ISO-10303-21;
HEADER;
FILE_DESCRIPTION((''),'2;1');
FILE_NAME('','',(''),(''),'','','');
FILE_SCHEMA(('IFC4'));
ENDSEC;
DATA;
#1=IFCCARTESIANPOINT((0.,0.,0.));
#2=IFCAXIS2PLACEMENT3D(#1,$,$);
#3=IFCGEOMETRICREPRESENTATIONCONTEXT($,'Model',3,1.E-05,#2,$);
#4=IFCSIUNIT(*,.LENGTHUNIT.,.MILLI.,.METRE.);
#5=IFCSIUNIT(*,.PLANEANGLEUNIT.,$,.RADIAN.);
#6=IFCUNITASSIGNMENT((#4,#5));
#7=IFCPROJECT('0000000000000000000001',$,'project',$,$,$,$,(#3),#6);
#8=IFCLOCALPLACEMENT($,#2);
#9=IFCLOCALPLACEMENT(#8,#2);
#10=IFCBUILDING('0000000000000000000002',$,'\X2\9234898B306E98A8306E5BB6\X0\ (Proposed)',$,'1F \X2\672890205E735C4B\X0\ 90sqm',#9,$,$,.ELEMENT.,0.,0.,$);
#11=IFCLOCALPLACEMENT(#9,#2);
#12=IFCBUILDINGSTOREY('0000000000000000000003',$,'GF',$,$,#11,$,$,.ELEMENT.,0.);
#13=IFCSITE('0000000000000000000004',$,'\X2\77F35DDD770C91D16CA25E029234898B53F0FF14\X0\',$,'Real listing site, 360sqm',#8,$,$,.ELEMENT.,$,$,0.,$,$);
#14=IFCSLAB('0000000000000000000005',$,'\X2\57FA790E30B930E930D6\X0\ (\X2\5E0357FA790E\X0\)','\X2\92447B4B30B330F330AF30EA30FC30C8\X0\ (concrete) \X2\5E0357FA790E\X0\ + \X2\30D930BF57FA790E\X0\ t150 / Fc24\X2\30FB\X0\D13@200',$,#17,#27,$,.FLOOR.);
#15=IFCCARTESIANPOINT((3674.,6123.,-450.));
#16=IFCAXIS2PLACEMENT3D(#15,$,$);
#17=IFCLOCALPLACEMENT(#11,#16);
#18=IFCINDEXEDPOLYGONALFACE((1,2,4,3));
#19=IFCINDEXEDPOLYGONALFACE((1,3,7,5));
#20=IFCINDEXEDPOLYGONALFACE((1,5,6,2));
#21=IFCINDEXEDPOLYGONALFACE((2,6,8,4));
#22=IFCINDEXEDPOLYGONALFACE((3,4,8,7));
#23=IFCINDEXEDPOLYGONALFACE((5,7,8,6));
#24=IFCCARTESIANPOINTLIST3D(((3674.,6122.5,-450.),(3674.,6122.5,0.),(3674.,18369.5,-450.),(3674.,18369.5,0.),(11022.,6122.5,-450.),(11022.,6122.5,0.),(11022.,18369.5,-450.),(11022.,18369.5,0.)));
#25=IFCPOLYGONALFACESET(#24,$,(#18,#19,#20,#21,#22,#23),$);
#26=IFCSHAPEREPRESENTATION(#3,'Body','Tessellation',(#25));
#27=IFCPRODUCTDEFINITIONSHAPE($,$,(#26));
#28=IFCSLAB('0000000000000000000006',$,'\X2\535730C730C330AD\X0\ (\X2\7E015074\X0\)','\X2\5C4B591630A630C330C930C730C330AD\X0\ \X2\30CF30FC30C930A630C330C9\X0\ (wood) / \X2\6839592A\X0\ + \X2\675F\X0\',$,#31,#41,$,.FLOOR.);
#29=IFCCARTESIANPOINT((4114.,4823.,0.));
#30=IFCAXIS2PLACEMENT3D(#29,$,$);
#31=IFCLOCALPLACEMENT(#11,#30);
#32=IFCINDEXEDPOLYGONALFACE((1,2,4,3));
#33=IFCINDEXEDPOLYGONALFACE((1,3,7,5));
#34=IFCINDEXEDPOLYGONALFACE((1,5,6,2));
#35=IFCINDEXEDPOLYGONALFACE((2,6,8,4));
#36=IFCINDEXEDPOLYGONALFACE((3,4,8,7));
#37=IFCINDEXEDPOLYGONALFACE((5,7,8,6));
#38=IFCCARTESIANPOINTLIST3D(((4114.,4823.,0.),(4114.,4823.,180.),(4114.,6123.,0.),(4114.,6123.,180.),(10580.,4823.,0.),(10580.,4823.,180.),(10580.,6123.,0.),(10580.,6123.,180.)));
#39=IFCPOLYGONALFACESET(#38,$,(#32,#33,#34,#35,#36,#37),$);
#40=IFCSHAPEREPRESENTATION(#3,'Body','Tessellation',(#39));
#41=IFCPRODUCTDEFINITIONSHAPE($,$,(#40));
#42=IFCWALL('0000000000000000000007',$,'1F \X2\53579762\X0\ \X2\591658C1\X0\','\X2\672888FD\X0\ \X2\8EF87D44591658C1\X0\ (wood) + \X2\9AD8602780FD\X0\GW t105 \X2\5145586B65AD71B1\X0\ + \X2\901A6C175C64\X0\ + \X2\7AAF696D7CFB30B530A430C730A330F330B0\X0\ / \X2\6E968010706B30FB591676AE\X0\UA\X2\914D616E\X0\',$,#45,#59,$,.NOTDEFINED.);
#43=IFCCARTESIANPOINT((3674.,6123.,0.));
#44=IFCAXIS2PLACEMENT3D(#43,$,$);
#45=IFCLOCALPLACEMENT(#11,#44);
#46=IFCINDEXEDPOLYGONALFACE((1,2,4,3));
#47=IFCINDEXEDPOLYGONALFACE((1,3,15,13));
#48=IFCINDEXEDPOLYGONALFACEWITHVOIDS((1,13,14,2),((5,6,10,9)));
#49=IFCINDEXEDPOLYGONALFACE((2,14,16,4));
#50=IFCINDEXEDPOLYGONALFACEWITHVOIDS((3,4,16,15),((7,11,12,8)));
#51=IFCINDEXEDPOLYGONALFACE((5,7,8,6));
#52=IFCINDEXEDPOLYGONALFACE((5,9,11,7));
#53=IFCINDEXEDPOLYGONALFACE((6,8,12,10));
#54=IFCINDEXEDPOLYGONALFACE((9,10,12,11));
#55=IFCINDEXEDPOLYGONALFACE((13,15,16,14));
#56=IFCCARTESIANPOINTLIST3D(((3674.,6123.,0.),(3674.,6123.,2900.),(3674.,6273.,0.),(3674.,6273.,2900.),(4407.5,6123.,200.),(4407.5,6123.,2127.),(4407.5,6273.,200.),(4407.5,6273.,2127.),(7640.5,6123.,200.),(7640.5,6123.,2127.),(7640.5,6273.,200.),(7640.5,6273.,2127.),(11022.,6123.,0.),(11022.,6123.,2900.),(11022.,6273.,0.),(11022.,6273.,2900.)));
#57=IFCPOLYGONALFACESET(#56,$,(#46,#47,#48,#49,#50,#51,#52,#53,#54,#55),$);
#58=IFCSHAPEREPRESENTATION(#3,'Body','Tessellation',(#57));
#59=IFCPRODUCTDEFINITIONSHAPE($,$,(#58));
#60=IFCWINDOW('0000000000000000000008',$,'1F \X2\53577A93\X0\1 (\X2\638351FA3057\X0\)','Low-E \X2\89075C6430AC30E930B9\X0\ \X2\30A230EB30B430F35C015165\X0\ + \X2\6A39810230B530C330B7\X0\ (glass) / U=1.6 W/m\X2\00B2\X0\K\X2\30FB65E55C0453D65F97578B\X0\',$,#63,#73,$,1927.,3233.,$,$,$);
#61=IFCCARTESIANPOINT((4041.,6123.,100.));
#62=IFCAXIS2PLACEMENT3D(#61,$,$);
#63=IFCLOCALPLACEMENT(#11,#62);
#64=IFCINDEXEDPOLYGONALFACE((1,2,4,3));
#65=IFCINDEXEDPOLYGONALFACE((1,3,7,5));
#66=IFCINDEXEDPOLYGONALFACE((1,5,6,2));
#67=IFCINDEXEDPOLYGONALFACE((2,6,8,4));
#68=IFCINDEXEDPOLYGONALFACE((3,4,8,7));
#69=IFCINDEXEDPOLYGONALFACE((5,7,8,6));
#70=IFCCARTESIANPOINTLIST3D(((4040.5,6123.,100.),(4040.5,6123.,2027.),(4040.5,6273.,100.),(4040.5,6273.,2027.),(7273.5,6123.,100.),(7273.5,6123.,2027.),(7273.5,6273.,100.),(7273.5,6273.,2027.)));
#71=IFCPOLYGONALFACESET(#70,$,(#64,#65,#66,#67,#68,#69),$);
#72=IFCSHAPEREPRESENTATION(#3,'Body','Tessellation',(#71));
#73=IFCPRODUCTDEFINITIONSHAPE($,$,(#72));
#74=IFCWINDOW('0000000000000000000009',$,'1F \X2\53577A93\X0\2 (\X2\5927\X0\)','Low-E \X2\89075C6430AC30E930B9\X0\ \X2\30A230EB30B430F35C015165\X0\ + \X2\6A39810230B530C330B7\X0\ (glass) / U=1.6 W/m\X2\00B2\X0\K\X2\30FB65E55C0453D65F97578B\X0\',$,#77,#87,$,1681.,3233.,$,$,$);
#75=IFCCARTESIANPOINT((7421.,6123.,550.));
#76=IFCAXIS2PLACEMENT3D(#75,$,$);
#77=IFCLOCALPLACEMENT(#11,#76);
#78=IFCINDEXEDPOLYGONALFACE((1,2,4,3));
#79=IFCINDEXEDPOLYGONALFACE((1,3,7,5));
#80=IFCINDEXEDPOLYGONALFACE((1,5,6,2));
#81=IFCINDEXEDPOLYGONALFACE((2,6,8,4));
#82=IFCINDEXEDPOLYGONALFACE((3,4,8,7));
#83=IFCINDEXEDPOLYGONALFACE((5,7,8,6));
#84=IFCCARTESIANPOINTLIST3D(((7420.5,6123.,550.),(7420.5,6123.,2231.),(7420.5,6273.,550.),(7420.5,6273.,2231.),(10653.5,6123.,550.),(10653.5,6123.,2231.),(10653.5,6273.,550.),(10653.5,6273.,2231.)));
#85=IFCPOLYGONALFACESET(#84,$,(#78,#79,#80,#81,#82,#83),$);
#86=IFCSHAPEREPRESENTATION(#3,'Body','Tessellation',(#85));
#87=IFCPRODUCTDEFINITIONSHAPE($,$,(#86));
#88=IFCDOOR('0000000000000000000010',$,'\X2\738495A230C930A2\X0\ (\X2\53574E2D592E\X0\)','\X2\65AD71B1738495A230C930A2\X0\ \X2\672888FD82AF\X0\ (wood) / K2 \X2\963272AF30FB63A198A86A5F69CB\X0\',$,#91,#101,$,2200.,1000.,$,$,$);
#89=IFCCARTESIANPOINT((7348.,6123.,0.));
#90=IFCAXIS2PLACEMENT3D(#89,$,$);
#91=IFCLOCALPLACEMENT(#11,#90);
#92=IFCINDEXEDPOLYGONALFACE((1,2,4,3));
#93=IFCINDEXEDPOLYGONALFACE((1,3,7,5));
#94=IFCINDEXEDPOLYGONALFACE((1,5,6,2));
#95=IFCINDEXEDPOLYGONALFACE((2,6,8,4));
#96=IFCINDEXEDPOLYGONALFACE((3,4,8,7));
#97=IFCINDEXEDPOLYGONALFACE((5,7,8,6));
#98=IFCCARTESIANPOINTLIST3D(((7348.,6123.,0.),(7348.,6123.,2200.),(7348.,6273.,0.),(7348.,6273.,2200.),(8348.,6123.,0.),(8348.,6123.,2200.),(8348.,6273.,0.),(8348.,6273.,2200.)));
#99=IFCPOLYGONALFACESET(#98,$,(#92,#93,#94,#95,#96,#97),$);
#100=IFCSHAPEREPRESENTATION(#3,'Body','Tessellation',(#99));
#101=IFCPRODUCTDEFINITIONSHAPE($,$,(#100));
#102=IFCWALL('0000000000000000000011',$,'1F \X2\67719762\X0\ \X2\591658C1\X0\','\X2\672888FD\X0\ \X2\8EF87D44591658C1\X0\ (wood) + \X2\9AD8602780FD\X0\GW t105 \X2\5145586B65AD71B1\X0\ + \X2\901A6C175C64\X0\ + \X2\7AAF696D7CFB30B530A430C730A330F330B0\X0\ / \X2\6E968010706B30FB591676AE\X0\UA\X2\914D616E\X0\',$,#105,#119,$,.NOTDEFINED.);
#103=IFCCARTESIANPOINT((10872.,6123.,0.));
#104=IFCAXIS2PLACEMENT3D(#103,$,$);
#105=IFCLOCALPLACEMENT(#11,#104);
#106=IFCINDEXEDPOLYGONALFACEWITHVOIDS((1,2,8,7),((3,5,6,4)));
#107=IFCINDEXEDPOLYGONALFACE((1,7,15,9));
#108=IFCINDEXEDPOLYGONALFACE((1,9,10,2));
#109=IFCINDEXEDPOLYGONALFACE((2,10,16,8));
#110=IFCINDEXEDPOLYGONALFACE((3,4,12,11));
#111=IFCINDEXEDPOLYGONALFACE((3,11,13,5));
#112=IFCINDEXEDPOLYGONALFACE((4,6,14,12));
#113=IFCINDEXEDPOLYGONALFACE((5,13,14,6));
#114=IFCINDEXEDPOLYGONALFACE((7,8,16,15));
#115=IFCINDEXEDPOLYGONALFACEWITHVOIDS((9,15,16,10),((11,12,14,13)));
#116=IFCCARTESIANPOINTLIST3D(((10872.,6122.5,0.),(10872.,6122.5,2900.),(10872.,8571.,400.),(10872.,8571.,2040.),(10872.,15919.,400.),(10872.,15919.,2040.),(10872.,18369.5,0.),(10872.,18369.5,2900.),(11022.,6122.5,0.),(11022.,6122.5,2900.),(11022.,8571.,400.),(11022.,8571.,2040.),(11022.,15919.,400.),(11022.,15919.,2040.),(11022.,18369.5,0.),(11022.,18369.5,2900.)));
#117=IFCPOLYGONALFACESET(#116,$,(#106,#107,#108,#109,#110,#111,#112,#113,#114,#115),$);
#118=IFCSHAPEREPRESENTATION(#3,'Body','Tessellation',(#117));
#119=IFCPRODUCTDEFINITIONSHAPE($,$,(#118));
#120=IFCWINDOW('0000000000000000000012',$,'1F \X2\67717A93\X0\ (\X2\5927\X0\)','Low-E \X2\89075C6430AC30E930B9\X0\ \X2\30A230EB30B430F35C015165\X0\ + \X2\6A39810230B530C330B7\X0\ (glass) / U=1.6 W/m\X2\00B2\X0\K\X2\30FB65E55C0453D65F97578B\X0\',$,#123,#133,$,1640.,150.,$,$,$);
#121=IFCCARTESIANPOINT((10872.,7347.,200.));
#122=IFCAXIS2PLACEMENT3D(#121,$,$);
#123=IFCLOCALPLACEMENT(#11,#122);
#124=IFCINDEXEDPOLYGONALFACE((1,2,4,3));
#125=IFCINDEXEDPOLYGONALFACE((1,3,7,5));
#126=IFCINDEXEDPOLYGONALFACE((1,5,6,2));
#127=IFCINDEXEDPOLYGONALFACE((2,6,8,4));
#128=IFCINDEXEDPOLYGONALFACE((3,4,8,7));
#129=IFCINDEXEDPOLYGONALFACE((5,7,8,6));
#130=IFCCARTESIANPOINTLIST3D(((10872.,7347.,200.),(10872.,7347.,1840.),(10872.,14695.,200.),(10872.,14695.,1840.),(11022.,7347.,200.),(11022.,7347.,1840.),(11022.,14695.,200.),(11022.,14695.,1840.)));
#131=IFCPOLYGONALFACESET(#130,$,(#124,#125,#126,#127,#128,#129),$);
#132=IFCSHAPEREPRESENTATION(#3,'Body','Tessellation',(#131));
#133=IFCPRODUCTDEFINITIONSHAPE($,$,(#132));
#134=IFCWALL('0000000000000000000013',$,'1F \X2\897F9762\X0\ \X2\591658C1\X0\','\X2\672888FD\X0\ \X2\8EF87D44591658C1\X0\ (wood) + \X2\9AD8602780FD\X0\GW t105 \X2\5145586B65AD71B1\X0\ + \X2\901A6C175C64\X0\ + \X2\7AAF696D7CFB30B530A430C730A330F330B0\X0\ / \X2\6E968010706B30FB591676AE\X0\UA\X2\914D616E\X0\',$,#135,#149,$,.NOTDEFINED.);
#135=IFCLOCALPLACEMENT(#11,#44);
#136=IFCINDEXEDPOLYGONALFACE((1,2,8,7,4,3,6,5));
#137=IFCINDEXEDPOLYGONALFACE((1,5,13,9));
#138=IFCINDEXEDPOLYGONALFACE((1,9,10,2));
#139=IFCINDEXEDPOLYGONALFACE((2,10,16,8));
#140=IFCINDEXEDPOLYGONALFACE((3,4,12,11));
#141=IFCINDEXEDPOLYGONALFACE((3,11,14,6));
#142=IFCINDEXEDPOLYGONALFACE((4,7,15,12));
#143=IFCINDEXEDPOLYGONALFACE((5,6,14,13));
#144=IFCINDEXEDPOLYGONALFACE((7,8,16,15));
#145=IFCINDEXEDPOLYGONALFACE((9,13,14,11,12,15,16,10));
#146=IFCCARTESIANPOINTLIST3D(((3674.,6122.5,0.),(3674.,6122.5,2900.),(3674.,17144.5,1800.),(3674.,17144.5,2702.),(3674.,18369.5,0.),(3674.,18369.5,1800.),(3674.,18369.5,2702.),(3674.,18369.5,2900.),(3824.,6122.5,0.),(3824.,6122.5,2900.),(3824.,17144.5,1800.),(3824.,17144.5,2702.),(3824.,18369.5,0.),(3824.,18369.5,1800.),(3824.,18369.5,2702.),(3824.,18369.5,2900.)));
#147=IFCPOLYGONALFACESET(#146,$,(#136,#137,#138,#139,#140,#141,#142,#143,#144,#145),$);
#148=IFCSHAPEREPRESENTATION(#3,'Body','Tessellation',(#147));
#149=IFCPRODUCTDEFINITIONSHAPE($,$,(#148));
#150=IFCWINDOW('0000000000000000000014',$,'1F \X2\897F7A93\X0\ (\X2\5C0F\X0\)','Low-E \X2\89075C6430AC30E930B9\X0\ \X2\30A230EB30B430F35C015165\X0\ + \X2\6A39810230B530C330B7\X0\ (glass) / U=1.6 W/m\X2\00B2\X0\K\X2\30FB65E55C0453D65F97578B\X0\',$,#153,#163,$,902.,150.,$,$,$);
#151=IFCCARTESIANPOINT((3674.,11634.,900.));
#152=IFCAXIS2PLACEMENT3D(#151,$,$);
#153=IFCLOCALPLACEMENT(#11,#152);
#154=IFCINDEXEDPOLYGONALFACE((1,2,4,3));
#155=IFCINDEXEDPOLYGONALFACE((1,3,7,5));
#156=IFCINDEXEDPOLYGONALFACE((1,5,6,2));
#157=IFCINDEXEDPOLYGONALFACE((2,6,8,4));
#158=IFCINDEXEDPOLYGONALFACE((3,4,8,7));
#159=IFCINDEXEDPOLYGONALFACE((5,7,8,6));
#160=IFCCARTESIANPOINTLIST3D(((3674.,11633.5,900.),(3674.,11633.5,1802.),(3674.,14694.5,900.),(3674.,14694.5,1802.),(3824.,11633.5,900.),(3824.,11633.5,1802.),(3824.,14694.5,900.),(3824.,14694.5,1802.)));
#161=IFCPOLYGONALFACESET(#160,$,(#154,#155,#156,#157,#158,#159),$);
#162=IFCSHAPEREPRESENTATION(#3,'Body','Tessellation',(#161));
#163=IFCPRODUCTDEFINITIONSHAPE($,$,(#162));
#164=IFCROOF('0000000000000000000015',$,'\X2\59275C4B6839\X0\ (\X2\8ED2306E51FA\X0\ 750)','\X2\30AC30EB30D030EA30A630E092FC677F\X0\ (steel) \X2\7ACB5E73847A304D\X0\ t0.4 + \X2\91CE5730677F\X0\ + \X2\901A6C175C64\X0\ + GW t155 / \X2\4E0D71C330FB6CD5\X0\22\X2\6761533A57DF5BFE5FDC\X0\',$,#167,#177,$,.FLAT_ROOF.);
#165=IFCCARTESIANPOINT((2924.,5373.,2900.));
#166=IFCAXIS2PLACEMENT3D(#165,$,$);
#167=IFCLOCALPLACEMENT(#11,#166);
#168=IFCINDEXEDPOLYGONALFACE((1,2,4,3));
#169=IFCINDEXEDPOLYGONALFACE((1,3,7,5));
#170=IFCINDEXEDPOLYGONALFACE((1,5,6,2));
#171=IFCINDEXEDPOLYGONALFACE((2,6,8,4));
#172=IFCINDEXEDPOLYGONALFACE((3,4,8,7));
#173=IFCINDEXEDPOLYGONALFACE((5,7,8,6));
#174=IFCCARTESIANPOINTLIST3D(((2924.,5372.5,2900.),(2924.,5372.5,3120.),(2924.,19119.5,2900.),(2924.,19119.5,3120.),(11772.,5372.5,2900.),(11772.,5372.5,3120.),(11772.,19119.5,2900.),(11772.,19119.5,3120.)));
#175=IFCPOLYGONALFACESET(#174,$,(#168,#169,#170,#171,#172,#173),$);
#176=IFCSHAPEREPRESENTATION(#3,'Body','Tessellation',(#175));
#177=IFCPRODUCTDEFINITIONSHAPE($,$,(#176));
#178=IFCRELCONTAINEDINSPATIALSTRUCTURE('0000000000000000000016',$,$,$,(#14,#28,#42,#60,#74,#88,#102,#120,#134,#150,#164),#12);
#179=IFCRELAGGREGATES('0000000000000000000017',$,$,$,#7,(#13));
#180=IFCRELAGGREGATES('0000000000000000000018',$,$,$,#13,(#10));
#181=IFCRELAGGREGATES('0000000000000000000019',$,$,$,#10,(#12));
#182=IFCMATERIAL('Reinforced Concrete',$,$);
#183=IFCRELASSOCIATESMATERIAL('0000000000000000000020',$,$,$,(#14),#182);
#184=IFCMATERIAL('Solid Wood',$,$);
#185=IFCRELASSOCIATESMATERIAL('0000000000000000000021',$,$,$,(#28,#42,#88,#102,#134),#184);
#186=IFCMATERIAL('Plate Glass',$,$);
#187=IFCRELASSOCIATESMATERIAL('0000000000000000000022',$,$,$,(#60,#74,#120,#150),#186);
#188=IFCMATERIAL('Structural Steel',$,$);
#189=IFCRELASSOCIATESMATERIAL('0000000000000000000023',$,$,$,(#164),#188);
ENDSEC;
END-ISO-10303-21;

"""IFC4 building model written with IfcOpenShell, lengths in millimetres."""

from ifc_helpers import new_model, si_unit, frame, frame_2d, origin, place, context, project, spatial, rectangle, extrude, material, element, fill, save


model = new_model("IFC4")

# Units and contexts
model_context = context("Model", 3, precision=1e-05, world=origin())
ifc_project = project(units=[si_unit("LENGTHUNIT", "METRE", prefix="MILLI"), si_unit("PLANEANGLEUNIT", "RADIAN")], contexts=[model_context])

# Site, building, storey
site_placement = place(None, origin())
site = spatial("IfcSite", under=ifc_project, at=site_placement, Name="石川県金沢市鈴見台４", ObjectType="Real listing site, 360sqm", CompositionType="ELEMENT", RefElevation=0.0)
building_placement = place(site_placement, origin())
building = spatial("IfcBuilding", under=site, at=building_placement, Name="鈴見の風の家 (Proposed)", ObjectType="1F 木造平屋 90sqm", CompositionType="ELEMENT", ElevationOfRefHeight=0.0, ElevationOfTerrain=0.0)
storey_placement = place(building_placement, origin())
storey = spatial("IfcBuildingStorey", under=building, at=storey_placement, Name="GF", CompositionType="ELEMENT", Elevation=0.0)

# Slabs
ifc_material_1 = material(Name="Reinforced Concrete")
slab_1_placement = place(storey_placement, frame((3674.0, 6123.0, -450.0)))
element("IfcSlab", 1, at=slab_1_placement, inside=storey, material=ifc_material_1, Name="基礎スラブ (布基礎)", Description="鉄筋コンクリート (concrete) 布基礎 + ベタ基礎 t150 / Fc24・D13@200", PredefinedType="FLOOR", context=model_context, shape_type="SweptSolid", body=[
    extrude(rectangle(XDim=7348.0, YDim=12247.0, at=frame_2d((3674.0, 6123.0))), frame((3674.0, 6123.0, -450.0)), (0.0, 0.0, 1.0), 450.0),
])
ifc_material_2 = material(Name="Solid Wood")
slab_2_placement = place(storey_placement, frame((4114.0, 4823.0, 0.0)))
element("IfcSlab", 2, at=slab_2_placement, inside=storey, material=ifc_material_2, Name="南デッキ (縁側)", Description="屋外ウッドデッキ ハードウッド (wood) / 根太 + 束", PredefinedType="FLOOR", context=model_context, shape_type="SweptSolid", body=[
    extrude(rectangle(XDim=6466.0, YDim=1300.0, at=frame_2d((3233.0, 650.0))), frame((4114.0, 4823.0, 0.0)), (0.0, 0.0, 1.0), 180.0),
])

# Wall, openings, windows, door
wall_1_placement = place(storey_placement, frame((3674.0, 6123.0, 0.0)))
wall_1 = element("IfcWall", 3, at=wall_1_placement, inside=storey, material=ifc_material_2, Name="1F 南面 外壁", Description="木製 軸組外壁 (wood) + 高性能GW t105 充填断熱 + 通気層 + 窯業系サイディング / 準耐火・外皮UA配慮", PredefinedType="NOTDEFINED", context=model_context, shape_type="SweptSolid", body=[
    extrude(rectangle(XDim=7348.0, YDim=150.0, at=frame_2d((3674.0, 75.0))), frame((3674.0, 6123.0, 0.0)), (0.0, 0.0, 1.0), 2900.0),
])
opening_1_placement = place(storey_placement, frame((4041.0, 6123.0, 100.0)))
opening_1 = element("IfcOpeningElement", 4, at=opening_1_placement, cuts=wall_1, PredefinedType="NOTDEFINED", context=model_context, shape_type="SweptSolid", body=[
    extrude(rectangle(XDim=3233.0, YDim=150.0, at=frame_2d((1616.0, 75.0))), frame((4041.0, 6123.0, 100.0)), (0.0, 0.0, 1.0), 1927.0),
])
opening_2_placement = place(storey_placement, frame((7421.0, 6123.0, 550.0)))
opening_2 = element("IfcOpeningElement", 5, at=opening_2_placement, cuts=wall_1, PredefinedType="NOTDEFINED", context=model_context, shape_type="SweptSolid", body=[
    extrude(rectangle(XDim=3233.0, YDim=150.0, at=frame_2d((1616.0, 75.0))), frame((7421.0, 6123.0, 550.0)), (0.0, 0.0, 1.0), 1681.0),
])
opening_3_placement = place(storey_placement, frame((7348.0, 6123.0, 0.0)))
opening_3 = element("IfcOpeningElement", 6, at=opening_3_placement, cuts=wall_1, PredefinedType="NOTDEFINED", context=model_context, shape_type="SweptSolid", body=[
    extrude(rectangle(XDim=1000.0, YDim=150.0, at=frame_2d((500.0, 75.0))), frame((7348.0, 6123.0, 0.0)), (0.0, 0.0, 1.0), 2200.0),
])
ifc_material_3 = material(Name="Plate Glass")
window_1_placement = place(storey_placement, frame((4041.0, 6123.0, 100.0)))
window_1 = element("IfcWindow", 7, at=window_1_placement, inside=storey, material=ifc_material_3, Name="1F 南窓1 (掃出し)", Description="Low-E 複層ガラス アルゴン封入 + 樹脂サッシ (glass) / U=1.6 W/m²K・日射取得型", OverallHeight=1927.0, OverallWidth=3233.0, context=model_context, shape_type="SweptSolid", body=[
    extrude(rectangle(XDim=3233.0, YDim=150.0, at=frame_2d((1616.0, 75.0))), frame((4041.0, 6123.0, 100.0)), (0.0, 0.0, 1.0), 1927.0),
])
fill(opening_1, window_1)
window_2_placement = place(storey_placement, frame((7421.0, 6123.0, 550.0)))
window_2 = element("IfcWindow", 8, at=window_2_placement, inside=storey, material=ifc_material_3, Name="1F 南窓2 (大)", Description="Low-E 複層ガラス アルゴン封入 + 樹脂サッシ (glass) / U=1.6 W/m²K・日射取得型", OverallHeight=1681.0, OverallWidth=3233.0, context=model_context, shape_type="SweptSolid", body=[
    extrude(rectangle(XDim=3233.0, YDim=150.0, at=frame_2d((1616.0, 75.0))), frame((7421.0, 6123.0, 550.0)), (0.0, 0.0, 1.0), 1681.0),
])
fill(opening_2, window_2)
door_placement = place(storey_placement, frame((7348.0, 6123.0, 0.0)))
door = element("IfcDoor", 9, at=door_placement, inside=storey, material=ifc_material_2, Name="玄関ドア (南中央)", Description="断熱玄関ドア 木製芯 (wood) / K2 防犯・採風機構", OverallHeight=2200.0, OverallWidth=1000.0, context=model_context, shape_type="SweptSolid", body=[
    extrude(rectangle(XDim=1000.0, YDim=150.0, at=frame_2d((500.0, 75.0))), frame((7348.0, 6123.0, 0.0)), (0.0, 0.0, 1.0), 2200.0),
])
fill(opening_3, door)

# Walls, openings, windows
wall_2_placement = place(storey_placement, frame((10872.0, 6123.0, 0.0)))
wall_2 = element("IfcWall", 10, at=wall_2_placement, inside=storey, material=ifc_material_2, Name="1F 東面 外壁", Description="木製 軸組外壁 (wood) + 高性能GW t105 充填断熱 + 通気層 + 窯業系サイディング / 準耐火・外皮UA配慮", PredefinedType="NOTDEFINED", context=model_context, shape_type="SweptSolid", body=[
    extrude(rectangle(XDim=150.0, YDim=12247.0, at=frame_2d((75.0, 6123.0))), frame((10872.0, 6123.0, 0.0)), (0.0, 0.0, 1.0), 2900.0),
])
opening_4_placement = place(storey_placement, frame((10872.0, 7347.0, 200.0)))
opening_4 = element("IfcOpeningElement", 11, at=opening_4_placement, cuts=wall_2, PredefinedType="NOTDEFINED", context=model_context, shape_type="SweptSolid", body=[
    extrude(rectangle(XDim=150.0, YDim=7348.0, at=frame_2d((75.0, 3674.0))), frame((10872.0, 7347.0, 200.0)), (0.0, 0.0, 1.0), 1640.0),
])
window_3_placement = place(storey_placement, frame((10872.0, 7347.0, 200.0)))
window_3 = element("IfcWindow", 12, at=window_3_placement, inside=storey, material=ifc_material_3, Name="1F 東窓 (大)", Description="Low-E 複層ガラス アルゴン封入 + 樹脂サッシ (glass) / U=1.6 W/m²K・日射取得型", OverallHeight=1640.0, OverallWidth=150.0, context=model_context, shape_type="SweptSolid", body=[
    extrude(rectangle(XDim=150.0, YDim=7348.0, at=frame_2d((75.0, 3674.0))), frame((10872.0, 7347.0, 200.0)), (0.0, 0.0, 1.0), 1640.0),
])
fill(opening_4, window_3)
wall_3_placement = place(storey_placement, frame((3674.0, 6123.0, 0.0)))
wall_3 = element("IfcWall", 13, at=wall_3_placement, inside=storey, material=ifc_material_2, Name="1F 西面 外壁", Description="木製 軸組外壁 (wood) + 高性能GW t105 充填断熱 + 通気層 + 窯業系サイディング / 準耐火・外皮UA配慮", PredefinedType="NOTDEFINED", context=model_context, shape_type="SweptSolid", body=[
    extrude(rectangle(XDim=150.0, YDim=12247.0, at=frame_2d((75.0, 6123.0))), frame((3674.0, 6123.0, 0.0)), (0.0, 0.0, 1.0), 2900.0),
])
opening_5_placement = place(storey_placement, frame((3674.0, 11634.0, 900.0)))
opening_5 = element("IfcOpeningElement", 14, at=opening_5_placement, cuts=wall_3, PredefinedType="NOTDEFINED", context=model_context, shape_type="SweptSolid", body=[
    extrude(rectangle(XDim=150.0, YDim=3061.0, at=frame_2d((75.0, 1530.0))), frame((3674.0, 11634.0, 900.0)), (0.0, 0.0, 1.0), 902.0),
])
window_4_placement = place(storey_placement, frame((3674.0, 11634.0, 900.0)))
window_4 = element("IfcWindow", 15, at=window_4_placement, inside=storey, material=ifc_material_3, Name="1F 西窓 (小)", Description="Low-E 複層ガラス アルゴン封入 + 樹脂サッシ (glass) / U=1.6 W/m²K・日射取得型", OverallHeight=902.0, OverallWidth=150.0, context=model_context, shape_type="SweptSolid", body=[
    extrude(rectangle(XDim=150.0, YDim=3061.0, at=frame_2d((75.0, 1530.0))), frame((3674.0, 11634.0, 900.0)), (0.0, 0.0, 1.0), 902.0),
])
fill(opening_5, window_4)

# Roof
ifc_material_4 = material(Name="Structural Steel")
roof_placement = place(storey_placement, frame((2924.0, 5373.0, 2900.0)))
element("IfcRoof", 16, at=roof_placement, inside=storey, material=ifc_material_4, Name="大屋根 (軒の出 750)", Description="ガルバリウム鋼板 (steel) 立平葺き t0.4 + 野地板 + 通気層 + GW t155 / 不燃・法22条区域対応", PredefinedType="FLAT_ROOF", context=model_context, shape_type="SweptSolid", body=[
    extrude(rectangle(XDim=8848.0, YDim=13747.0, at=frame_2d((4424.0, 6873.0))), frame((2924.0, 5373.0, 2900.0)), (0.0, 0.0, 1.0), 220.0),
])

save(model, "model.ifc")
